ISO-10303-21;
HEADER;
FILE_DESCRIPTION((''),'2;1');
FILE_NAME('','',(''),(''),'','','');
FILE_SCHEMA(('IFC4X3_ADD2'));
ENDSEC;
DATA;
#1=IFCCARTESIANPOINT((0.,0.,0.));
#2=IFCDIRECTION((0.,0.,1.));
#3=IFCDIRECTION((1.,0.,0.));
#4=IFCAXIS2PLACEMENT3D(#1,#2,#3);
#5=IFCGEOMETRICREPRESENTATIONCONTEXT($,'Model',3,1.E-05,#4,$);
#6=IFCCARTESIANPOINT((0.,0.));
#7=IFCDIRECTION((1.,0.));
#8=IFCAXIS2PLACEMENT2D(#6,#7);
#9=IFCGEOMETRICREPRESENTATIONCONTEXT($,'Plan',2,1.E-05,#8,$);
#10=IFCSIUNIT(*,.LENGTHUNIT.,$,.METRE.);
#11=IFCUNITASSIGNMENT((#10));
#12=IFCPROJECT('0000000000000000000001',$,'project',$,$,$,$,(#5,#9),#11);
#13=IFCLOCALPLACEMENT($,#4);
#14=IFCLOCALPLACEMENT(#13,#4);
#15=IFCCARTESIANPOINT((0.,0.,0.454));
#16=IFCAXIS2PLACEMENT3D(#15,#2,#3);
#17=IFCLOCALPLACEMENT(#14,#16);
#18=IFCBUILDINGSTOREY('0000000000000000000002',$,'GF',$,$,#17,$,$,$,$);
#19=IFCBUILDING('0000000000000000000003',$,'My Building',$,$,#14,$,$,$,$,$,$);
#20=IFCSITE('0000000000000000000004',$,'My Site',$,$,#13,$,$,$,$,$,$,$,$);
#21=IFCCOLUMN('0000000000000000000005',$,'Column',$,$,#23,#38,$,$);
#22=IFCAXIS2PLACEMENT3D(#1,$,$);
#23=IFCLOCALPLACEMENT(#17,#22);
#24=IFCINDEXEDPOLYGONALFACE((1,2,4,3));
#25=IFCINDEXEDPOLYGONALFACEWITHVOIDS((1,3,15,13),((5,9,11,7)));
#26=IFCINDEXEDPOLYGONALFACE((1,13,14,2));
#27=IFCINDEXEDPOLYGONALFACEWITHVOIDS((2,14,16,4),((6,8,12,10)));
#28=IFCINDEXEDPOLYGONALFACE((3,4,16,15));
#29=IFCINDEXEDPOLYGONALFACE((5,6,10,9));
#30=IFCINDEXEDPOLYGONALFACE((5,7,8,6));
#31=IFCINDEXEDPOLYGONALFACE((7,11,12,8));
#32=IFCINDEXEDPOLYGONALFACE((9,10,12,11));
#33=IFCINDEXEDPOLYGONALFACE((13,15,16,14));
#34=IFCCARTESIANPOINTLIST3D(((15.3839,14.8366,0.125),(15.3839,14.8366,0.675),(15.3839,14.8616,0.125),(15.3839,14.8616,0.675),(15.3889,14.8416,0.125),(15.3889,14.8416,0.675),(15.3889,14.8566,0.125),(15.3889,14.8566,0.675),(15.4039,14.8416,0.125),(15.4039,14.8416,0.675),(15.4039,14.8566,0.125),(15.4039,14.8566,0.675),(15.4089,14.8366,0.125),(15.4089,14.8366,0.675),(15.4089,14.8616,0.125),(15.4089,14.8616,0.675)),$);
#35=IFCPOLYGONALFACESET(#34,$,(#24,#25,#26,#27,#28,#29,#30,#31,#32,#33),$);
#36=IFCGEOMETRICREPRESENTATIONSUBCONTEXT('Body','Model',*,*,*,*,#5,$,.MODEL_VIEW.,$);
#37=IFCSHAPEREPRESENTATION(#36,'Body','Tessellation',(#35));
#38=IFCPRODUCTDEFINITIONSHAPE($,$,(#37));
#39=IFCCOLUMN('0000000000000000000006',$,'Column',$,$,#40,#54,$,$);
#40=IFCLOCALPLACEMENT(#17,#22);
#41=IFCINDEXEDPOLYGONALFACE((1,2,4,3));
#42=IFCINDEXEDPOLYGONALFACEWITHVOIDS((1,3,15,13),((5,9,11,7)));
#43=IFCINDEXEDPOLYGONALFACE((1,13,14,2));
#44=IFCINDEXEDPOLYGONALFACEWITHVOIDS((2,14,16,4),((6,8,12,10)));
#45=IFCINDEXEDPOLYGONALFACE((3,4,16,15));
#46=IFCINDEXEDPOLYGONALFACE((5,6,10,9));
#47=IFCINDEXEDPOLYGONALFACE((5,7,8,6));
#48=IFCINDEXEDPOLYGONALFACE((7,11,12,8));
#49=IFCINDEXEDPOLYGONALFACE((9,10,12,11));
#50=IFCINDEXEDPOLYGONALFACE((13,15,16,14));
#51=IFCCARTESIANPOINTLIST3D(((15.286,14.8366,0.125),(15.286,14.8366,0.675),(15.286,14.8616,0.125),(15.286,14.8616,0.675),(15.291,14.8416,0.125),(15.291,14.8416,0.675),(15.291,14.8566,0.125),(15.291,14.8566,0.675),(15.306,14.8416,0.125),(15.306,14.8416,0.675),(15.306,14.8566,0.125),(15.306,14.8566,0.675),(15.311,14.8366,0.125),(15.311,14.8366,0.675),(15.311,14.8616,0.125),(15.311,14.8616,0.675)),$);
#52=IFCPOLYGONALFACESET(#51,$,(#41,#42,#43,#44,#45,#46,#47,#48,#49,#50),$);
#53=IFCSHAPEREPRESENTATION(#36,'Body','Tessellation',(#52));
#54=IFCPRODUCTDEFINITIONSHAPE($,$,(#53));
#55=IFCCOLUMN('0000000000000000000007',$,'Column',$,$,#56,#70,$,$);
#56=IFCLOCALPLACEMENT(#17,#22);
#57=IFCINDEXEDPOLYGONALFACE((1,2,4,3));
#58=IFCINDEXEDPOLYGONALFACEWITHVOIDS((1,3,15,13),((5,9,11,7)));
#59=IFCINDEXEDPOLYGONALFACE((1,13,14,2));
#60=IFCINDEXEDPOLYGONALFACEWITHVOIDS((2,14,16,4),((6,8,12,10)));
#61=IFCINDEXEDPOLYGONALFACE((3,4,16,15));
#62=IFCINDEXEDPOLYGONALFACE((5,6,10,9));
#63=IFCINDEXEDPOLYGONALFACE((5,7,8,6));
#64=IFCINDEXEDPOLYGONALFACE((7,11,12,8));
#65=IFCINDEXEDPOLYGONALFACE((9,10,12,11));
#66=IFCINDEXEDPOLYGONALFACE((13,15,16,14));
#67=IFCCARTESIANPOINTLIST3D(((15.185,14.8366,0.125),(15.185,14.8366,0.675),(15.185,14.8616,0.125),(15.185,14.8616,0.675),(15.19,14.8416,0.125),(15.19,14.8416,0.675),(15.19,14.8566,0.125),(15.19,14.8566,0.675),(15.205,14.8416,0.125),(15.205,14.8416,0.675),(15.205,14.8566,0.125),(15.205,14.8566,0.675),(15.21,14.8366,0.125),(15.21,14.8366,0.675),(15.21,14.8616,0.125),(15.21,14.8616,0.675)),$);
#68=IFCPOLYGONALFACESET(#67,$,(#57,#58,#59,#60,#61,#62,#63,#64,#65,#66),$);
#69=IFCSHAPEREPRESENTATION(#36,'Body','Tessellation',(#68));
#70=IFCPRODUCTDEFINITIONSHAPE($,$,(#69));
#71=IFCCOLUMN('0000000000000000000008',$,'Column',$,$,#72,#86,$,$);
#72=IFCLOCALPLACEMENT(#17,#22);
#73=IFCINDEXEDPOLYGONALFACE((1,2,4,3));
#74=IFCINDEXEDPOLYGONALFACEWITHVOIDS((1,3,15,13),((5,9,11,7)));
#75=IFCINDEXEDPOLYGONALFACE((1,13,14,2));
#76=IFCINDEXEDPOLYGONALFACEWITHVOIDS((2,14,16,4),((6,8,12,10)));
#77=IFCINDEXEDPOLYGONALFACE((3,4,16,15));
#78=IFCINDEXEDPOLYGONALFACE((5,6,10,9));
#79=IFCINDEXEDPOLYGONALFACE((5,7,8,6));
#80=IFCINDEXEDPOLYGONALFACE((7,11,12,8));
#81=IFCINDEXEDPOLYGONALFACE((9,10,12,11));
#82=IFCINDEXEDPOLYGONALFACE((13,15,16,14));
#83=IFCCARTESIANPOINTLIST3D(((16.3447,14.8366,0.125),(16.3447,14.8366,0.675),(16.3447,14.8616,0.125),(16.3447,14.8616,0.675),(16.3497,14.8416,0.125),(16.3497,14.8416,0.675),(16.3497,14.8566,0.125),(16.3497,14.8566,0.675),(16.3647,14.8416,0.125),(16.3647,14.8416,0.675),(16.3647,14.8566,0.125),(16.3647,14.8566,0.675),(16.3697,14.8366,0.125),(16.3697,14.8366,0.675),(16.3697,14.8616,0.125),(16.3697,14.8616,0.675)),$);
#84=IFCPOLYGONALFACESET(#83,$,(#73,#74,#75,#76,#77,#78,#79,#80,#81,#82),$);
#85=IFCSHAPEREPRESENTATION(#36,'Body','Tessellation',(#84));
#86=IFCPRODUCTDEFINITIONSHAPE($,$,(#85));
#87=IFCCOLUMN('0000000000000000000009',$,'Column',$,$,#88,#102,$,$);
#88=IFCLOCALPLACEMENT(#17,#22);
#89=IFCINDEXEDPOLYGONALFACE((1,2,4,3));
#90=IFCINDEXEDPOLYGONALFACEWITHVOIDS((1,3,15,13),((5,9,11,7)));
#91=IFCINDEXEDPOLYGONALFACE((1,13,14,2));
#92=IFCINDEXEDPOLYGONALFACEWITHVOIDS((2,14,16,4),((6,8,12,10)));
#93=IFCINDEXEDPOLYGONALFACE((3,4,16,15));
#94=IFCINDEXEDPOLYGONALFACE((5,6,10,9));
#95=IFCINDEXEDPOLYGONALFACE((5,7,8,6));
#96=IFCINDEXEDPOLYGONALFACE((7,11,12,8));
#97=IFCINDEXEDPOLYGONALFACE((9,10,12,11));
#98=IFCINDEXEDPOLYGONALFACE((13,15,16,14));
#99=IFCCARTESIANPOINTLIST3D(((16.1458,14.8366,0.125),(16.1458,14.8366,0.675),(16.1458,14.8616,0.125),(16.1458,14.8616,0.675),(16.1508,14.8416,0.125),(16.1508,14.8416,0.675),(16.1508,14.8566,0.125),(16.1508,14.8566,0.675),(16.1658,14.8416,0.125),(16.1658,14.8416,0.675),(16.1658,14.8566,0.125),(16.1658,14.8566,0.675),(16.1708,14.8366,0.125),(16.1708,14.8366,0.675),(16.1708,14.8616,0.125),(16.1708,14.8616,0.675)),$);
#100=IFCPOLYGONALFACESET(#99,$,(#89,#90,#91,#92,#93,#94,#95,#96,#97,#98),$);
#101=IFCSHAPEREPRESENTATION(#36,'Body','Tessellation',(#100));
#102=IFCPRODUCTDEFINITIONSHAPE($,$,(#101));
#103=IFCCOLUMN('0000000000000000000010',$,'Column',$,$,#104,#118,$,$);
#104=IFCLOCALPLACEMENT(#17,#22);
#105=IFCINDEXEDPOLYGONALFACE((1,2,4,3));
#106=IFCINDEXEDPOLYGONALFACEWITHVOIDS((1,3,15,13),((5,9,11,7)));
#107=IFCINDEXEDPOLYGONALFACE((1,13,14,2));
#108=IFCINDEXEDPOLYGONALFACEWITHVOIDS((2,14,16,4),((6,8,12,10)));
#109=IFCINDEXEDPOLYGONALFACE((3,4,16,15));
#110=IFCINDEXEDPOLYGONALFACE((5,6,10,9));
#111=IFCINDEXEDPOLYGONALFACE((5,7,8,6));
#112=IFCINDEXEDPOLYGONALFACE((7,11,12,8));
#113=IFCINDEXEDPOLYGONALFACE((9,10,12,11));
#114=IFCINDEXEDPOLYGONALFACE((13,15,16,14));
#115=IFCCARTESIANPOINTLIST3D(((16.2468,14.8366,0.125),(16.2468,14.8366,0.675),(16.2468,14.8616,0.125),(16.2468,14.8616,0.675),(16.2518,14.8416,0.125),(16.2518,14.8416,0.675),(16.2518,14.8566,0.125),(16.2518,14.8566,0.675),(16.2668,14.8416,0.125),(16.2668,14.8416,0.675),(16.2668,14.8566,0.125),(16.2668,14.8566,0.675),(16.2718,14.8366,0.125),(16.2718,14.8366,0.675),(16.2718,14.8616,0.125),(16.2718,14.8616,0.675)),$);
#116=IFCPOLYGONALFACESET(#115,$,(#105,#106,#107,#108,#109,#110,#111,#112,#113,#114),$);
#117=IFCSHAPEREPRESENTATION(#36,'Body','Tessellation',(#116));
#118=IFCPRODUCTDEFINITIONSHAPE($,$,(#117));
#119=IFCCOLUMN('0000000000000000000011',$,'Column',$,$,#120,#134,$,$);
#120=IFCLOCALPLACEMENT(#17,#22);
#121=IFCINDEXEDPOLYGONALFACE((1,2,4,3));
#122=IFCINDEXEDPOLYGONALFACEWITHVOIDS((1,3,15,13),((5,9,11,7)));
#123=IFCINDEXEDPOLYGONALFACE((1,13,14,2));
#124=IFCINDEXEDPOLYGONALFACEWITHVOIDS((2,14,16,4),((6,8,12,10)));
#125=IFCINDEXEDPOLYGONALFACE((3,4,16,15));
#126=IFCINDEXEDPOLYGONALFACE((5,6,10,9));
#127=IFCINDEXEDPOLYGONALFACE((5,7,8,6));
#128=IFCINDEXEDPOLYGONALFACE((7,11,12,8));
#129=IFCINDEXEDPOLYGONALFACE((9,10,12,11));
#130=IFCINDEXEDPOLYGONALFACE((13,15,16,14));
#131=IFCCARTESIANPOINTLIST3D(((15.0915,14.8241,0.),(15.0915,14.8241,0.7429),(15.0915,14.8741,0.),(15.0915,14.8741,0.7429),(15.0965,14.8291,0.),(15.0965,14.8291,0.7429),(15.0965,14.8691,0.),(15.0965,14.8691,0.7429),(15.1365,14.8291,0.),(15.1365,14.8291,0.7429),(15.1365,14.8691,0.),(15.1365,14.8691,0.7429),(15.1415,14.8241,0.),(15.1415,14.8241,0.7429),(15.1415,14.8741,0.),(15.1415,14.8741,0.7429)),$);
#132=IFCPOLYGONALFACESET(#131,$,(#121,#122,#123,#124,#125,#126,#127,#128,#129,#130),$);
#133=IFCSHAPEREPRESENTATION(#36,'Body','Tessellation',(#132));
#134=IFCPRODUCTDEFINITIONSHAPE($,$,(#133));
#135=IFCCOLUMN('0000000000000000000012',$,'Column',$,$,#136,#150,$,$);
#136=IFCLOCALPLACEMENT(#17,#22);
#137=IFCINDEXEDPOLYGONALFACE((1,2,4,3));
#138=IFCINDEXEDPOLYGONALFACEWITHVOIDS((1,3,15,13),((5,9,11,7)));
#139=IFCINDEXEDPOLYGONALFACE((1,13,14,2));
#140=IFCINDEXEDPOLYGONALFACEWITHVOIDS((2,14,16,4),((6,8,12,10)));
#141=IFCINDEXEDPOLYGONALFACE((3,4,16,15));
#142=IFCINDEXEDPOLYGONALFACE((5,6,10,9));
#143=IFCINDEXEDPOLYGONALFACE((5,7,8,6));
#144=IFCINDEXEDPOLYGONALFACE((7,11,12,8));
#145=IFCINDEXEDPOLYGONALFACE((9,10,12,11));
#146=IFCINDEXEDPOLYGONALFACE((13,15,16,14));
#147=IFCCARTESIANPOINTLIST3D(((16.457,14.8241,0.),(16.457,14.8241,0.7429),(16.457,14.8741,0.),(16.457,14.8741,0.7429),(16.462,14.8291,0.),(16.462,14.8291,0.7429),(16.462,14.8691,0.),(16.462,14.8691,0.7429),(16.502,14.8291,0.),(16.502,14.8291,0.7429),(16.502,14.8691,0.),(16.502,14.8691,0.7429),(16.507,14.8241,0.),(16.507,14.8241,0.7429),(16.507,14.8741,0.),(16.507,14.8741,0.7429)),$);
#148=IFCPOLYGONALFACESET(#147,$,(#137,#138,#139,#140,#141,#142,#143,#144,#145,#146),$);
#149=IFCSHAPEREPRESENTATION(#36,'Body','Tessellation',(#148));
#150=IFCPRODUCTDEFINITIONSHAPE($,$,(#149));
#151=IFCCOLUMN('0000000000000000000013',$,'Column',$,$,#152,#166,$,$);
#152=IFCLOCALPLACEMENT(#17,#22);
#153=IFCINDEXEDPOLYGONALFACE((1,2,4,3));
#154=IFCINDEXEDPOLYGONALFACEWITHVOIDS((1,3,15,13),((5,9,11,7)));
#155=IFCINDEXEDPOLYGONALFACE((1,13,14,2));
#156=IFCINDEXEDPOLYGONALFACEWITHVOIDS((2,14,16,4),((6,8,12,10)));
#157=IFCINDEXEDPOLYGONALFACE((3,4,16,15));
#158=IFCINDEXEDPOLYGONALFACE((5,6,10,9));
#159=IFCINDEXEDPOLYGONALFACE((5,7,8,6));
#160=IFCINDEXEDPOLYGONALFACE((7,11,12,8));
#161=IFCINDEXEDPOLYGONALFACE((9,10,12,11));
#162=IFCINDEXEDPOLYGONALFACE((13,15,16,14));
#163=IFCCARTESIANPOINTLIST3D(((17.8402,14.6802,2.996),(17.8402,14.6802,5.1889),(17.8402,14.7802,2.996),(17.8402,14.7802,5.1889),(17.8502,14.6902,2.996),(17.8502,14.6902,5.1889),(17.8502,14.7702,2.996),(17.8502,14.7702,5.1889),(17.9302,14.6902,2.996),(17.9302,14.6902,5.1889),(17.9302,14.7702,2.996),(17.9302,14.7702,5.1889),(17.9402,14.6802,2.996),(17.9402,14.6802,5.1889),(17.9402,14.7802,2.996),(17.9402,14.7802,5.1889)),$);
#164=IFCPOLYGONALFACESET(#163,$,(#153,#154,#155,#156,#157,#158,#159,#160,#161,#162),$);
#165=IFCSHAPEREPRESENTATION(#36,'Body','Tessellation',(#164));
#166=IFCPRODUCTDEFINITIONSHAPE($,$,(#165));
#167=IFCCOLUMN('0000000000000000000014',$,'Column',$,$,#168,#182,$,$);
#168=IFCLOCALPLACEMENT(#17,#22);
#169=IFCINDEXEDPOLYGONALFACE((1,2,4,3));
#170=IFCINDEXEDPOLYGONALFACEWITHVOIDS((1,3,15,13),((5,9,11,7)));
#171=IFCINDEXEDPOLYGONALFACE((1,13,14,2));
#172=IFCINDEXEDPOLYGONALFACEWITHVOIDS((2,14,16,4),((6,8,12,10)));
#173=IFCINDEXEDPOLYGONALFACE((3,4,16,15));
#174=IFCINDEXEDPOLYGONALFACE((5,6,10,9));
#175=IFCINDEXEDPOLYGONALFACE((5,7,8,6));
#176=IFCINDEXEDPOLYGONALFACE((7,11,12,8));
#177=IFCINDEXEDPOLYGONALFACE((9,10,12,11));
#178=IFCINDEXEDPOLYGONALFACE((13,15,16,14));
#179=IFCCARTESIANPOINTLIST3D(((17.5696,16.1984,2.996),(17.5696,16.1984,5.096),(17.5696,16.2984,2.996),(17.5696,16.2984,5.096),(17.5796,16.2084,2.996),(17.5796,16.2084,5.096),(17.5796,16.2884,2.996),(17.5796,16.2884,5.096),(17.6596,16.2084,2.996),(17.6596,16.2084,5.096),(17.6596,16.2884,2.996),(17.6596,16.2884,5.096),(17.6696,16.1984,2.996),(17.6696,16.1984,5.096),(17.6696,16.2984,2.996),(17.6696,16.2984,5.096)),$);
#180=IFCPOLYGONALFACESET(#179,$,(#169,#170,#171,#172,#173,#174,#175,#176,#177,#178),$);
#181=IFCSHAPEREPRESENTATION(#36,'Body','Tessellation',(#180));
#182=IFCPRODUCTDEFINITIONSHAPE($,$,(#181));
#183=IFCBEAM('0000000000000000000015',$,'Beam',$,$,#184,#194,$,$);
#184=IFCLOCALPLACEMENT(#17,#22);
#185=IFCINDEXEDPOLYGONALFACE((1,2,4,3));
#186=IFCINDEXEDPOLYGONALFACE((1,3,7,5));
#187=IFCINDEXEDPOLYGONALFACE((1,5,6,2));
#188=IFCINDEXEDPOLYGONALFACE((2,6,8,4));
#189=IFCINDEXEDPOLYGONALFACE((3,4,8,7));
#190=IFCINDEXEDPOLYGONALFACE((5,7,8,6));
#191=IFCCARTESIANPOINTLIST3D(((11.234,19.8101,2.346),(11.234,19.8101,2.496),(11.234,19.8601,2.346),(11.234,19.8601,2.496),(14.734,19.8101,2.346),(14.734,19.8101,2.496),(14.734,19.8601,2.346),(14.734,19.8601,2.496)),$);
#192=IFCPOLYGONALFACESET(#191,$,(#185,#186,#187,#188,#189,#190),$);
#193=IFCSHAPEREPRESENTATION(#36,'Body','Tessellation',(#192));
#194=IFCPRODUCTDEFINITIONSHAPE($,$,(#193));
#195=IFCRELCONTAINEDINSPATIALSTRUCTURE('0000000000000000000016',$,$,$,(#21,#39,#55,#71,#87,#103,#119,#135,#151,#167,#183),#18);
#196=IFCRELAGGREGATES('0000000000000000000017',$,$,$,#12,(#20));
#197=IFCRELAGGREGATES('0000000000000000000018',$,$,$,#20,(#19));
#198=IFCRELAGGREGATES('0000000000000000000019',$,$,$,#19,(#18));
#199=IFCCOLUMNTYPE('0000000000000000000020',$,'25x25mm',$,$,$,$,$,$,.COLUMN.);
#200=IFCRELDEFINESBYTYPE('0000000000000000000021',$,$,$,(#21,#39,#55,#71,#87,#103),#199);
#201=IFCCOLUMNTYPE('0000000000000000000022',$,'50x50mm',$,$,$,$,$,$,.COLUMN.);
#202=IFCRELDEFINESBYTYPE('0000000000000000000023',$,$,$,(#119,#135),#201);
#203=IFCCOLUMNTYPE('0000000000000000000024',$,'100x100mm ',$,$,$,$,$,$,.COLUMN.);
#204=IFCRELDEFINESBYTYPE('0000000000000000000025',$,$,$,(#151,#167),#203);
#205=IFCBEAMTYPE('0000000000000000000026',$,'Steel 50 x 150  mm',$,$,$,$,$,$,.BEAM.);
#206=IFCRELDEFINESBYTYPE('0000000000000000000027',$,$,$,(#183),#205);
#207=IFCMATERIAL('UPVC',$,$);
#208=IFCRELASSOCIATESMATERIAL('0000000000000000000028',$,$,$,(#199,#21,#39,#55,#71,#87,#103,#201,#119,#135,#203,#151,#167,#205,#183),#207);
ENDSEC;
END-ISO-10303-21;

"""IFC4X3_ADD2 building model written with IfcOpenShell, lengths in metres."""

from ifc_helpers import new_model, si_unit, frame, origin_with_axes, origin_2d_with_axis, place, context, subcontext, project, spatial, rectangle, hollow_rectangle, extrude, material, material_profile, profile_set, profile_usage, type_object, element, save


model = new_model("IFC4X3_ADD2")

# Units and contexts
model_context = context("Model", 3, precision=1e-05, world=origin_with_axes())
plan_context = context("Plan", 2, precision=1e-05, world=origin_2d_with_axis())
body_context = subcontext(model_context, "Body", "Model", "MODEL_VIEW")
ifc_project = project(units=[si_unit("LENGTHUNIT", "METRE")], contexts=[model_context, plan_context])

# Site, building, storey
site_placement = place(None, origin_with_axes())
site = spatial("IfcSite", under=ifc_project, at=site_placement, Name="My Site")
building_placement = place(site_placement, origin_with_axes())
building = spatial("IfcBuilding", under=site, at=building_placement, Name="My Building")
storey_placement = place(building_placement, frame((0.0, 0.0, 0.454), z_axis=(0.0, 0.0, 1.0), x_axis=(1.0, 0.0, 0.0)))
storey = spatial("IfcBuildingStorey", under=building, at=storey_placement, Name="GF")

# Columns
ifc_material_1 = material(Name="UPVC")
ifc_material_profile_1 = material_profile(ifc_material_1, hollow_rectangle(XDim=0.025, YDim=0.025, WallThickness=0.005))
ifc_profile_set_1 = profile_set([ifc_material_profile_1])
ifc_profile_usage_1 = profile_usage(ifc_profile_set_1)
column_type_1 = type_object("IfcColumnType", Name="25x25mm", PredefinedType="COLUMN", material=ifc_profile_set_1)
column_1_placement = place(storey_placement, frame((15.3964, 14.8491, 0.125), z_axis=(0.0, 0.0, 1.0), x_axis=(0.0, -1.0, 0.0)))
element("IfcColumn", 1, at=column_1_placement, inside=storey, type_object=column_type_1, material=ifc_profile_usage_1, Name="Column", context=body_context, shape_type="SweptSolid", body=[
    extrude(hollow_rectangle(XDim=0.025, YDim=0.025, WallThickness=0.005), origin_with_axes(), (0.0, 0.0, 1.0), 0.55),
])
ifc_profile_usage_2 = profile_usage(ifc_profile_set_1)
column_2_placement = place(storey_placement, frame((15.2985, 14.8491, 0.125), z_axis=(0.0, 0.0, 1.0), x_axis=(0.0, -1.0, 0.0)))
element("IfcColumn", 2, at=column_2_placement, inside=storey, type_object=column_type_1, material=ifc_profile_usage_2, Name="Column", context=body_context, shape_type="SweptSolid", body=[
    extrude(hollow_rectangle(XDim=0.025, YDim=0.025, WallThickness=0.005), origin_with_axes(), (0.0, 0.0, 1.0), 0.55),
])
ifc_profile_usage_3 = profile_usage(ifc_profile_set_1)
column_3_placement = place(storey_placement, frame((15.1975, 14.8491, 0.125), z_axis=(0.0, 0.0, 1.0), x_axis=(0.0, -1.0, 0.0)))
element("IfcColumn", 3, at=column_3_placement, inside=storey, type_object=column_type_1, material=ifc_profile_usage_3, Name="Column", context=body_context, shape_type="SweptSolid", body=[
    extrude(hollow_rectangle(XDim=0.025, YDim=0.025, WallThickness=0.005), origin_with_axes(), (0.0, 0.0, 1.0), 0.55),
])
ifc_profile_usage_4 = profile_usage(ifc_profile_set_1)
column_4_placement = place(storey_placement, frame((16.3572, 14.8491, 0.125), z_axis=(0.0, 0.0, 1.0), x_axis=(0.0, -1.0, 0.0)))
element("IfcColumn", 4, at=column_4_placement, inside=storey, type_object=column_type_1, material=ifc_profile_usage_4, Name="Column", context=body_context, shape_type="SweptSolid", body=[
    extrude(hollow_rectangle(XDim=0.025, YDim=0.025, WallThickness=0.005), origin_with_axes(), (0.0, 0.0, 1.0), 0.55),
])
ifc_profile_usage_5 = profile_usage(ifc_profile_set_1)
column_5_placement = place(storey_placement, frame((16.1583, 14.8491, 0.125), z_axis=(0.0, 0.0, 1.0), x_axis=(0.0, -1.0, 0.0)))
element("IfcColumn", 5, at=column_5_placement, inside=storey, type_object=column_type_1, material=ifc_profile_usage_5, Name="Column", context=body_context, shape_type="SweptSolid", body=[
    extrude(hollow_rectangle(XDim=0.025, YDim=0.025, WallThickness=0.005), origin_with_axes(), (0.0, 0.0, 1.0), 0.55),
])
ifc_profile_usage_6 = profile_usage(ifc_profile_set_1)
column_6_placement = place(storey_placement, frame((16.2593, 14.8491, 0.125), z_axis=(0.0, 0.0, 1.0), x_axis=(0.0, -1.0, 0.0)))
element("IfcColumn", 6, at=column_6_placement, inside=storey, type_object=column_type_1, material=ifc_profile_usage_6, Name="Column", context=body_context, shape_type="SweptSolid", body=[
    extrude(hollow_rectangle(XDim=0.025, YDim=0.025, WallThickness=0.005), origin_with_axes(), (0.0, 0.0, 1.0), 0.55),
])
ifc_material_profile_2 = material_profile(ifc_material_1, hollow_rectangle(XDim=0.05, YDim=0.05, WallThickness=0.005))
ifc_profile_set_2 = profile_set([ifc_material_profile_2])
ifc_profile_usage_7 = profile_usage(ifc_profile_set_2)
column_type_2 = type_object("IfcColumnType", Name="50x50mm", PredefinedType="COLUMN", material=ifc_profile_set_2)
column_7_placement = place(storey_placement, frame((15.1165, 14.8491, 0.0), z_axis=(0.0, 0.0, 1.0), x_axis=(1.0, 0.0, 0.0)))
element("IfcColumn", 7, at=column_7_placement, inside=storey, type_object=column_type_2, material=ifc_profile_usage_7, Name="Column", context=body_context, shape_type="SweptSolid", body=[
    extrude(hollow_rectangle(XDim=0.05, YDim=0.05, WallThickness=0.005), origin_with_axes(), (0.0, 0.0, 1.0), 0.7429),
])
ifc_profile_usage_8 = profile_usage(ifc_profile_set_2)
column_8_placement = place(storey_placement, frame((16.482, 14.8491, 0.0), z_axis=(0.0, 0.0, 1.0), x_axis=(1.0, 0.0, 0.0)))
element("IfcColumn", 8, at=column_8_placement, inside=storey, type_object=column_type_2, material=ifc_profile_usage_8, Name="Column", context=body_context, shape_type="SweptSolid", body=[
    extrude(hollow_rectangle(XDim=0.05, YDim=0.05, WallThickness=0.005), origin_with_axes(), (0.0, 0.0, 1.0), 0.7429),
])
ifc_material_profile_3 = material_profile(ifc_material_1, hollow_rectangle(XDim=0.1, YDim=0.1, WallThickness=0.01))
ifc_profile_set_3 = profile_set([ifc_material_profile_3])
ifc_profile_usage_9 = profile_usage(ifc_profile_set_3)
column_type_3 = type_object("IfcColumnType", Name="100x100mm ", PredefinedType="COLUMN", material=ifc_profile_set_3)
column_9_placement = place(storey_placement, frame((17.8902, 14.7302, 2.996), z_axis=(0.0, 0.0, 1.0), x_axis=(0.0, -1.0, 0.0)))
element("IfcColumn", 9, at=column_9_placement, inside=storey, type_object=column_type_3, material=ifc_profile_usage_9, Name="Column", context=body_context, shape_type="SweptSolid", body=[
    extrude(hollow_rectangle(XDim=0.1, YDim=0.1, WallThickness=0.01), origin_with_axes(), (0.0, 0.0, 1.0), 2.1929),
])
ifc_profile_usage_10 = profile_usage(ifc_profile_set_3)
column_10_placement = place(storey_placement, frame((17.6196, 16.2484, 2.996), z_axis=(0.0, 0.0, 1.0), x_axis=(0.0, -1.0, 0.0)))
element("IfcColumn", 10, at=column_10_placement, inside=storey, type_object=column_type_3, material=ifc_profile_usage_10, Name="Column", context=body_context, shape_type="SweptSolid", body=[
    extrude(hollow_rectangle(XDim=0.1, YDim=0.1, WallThickness=0.01), origin_with_axes(), (0.0, 0.0, 1.0), 2.1),
])

# Beam
ifc_material_profile_4 = material_profile(ifc_material_1, rectangle(XDim=0.05, YDim=0.15))
ifc_profile_set_4 = profile_set([ifc_material_profile_4])
ifc_profile_usage_11 = profile_usage(ifc_profile_set_4)
beam_type_1 = type_object("IfcBeamType", Name="Steel 50 x 150  mm", PredefinedType="BEAM", material=ifc_profile_set_4)
beam_1_placement = place(storey_placement, frame((11.234, 19.8351, 2.421), z_axis=(1.0, 0.0, 0.0), x_axis=(0.0, 1.0, 0.0)))
element("IfcBeam", 11, at=beam_1_placement, inside=storey, type_object=beam_type_1, material=ifc_profile_usage_11, Name="Beam", context=body_context, shape_type="SweptSolid", body=[
    extrude(rectangle(XDim=0.05, YDim=0.15), origin_with_axes(), (0.0, 0.0, 1.0), 3.5),
])

save(model, "model.ifc")
